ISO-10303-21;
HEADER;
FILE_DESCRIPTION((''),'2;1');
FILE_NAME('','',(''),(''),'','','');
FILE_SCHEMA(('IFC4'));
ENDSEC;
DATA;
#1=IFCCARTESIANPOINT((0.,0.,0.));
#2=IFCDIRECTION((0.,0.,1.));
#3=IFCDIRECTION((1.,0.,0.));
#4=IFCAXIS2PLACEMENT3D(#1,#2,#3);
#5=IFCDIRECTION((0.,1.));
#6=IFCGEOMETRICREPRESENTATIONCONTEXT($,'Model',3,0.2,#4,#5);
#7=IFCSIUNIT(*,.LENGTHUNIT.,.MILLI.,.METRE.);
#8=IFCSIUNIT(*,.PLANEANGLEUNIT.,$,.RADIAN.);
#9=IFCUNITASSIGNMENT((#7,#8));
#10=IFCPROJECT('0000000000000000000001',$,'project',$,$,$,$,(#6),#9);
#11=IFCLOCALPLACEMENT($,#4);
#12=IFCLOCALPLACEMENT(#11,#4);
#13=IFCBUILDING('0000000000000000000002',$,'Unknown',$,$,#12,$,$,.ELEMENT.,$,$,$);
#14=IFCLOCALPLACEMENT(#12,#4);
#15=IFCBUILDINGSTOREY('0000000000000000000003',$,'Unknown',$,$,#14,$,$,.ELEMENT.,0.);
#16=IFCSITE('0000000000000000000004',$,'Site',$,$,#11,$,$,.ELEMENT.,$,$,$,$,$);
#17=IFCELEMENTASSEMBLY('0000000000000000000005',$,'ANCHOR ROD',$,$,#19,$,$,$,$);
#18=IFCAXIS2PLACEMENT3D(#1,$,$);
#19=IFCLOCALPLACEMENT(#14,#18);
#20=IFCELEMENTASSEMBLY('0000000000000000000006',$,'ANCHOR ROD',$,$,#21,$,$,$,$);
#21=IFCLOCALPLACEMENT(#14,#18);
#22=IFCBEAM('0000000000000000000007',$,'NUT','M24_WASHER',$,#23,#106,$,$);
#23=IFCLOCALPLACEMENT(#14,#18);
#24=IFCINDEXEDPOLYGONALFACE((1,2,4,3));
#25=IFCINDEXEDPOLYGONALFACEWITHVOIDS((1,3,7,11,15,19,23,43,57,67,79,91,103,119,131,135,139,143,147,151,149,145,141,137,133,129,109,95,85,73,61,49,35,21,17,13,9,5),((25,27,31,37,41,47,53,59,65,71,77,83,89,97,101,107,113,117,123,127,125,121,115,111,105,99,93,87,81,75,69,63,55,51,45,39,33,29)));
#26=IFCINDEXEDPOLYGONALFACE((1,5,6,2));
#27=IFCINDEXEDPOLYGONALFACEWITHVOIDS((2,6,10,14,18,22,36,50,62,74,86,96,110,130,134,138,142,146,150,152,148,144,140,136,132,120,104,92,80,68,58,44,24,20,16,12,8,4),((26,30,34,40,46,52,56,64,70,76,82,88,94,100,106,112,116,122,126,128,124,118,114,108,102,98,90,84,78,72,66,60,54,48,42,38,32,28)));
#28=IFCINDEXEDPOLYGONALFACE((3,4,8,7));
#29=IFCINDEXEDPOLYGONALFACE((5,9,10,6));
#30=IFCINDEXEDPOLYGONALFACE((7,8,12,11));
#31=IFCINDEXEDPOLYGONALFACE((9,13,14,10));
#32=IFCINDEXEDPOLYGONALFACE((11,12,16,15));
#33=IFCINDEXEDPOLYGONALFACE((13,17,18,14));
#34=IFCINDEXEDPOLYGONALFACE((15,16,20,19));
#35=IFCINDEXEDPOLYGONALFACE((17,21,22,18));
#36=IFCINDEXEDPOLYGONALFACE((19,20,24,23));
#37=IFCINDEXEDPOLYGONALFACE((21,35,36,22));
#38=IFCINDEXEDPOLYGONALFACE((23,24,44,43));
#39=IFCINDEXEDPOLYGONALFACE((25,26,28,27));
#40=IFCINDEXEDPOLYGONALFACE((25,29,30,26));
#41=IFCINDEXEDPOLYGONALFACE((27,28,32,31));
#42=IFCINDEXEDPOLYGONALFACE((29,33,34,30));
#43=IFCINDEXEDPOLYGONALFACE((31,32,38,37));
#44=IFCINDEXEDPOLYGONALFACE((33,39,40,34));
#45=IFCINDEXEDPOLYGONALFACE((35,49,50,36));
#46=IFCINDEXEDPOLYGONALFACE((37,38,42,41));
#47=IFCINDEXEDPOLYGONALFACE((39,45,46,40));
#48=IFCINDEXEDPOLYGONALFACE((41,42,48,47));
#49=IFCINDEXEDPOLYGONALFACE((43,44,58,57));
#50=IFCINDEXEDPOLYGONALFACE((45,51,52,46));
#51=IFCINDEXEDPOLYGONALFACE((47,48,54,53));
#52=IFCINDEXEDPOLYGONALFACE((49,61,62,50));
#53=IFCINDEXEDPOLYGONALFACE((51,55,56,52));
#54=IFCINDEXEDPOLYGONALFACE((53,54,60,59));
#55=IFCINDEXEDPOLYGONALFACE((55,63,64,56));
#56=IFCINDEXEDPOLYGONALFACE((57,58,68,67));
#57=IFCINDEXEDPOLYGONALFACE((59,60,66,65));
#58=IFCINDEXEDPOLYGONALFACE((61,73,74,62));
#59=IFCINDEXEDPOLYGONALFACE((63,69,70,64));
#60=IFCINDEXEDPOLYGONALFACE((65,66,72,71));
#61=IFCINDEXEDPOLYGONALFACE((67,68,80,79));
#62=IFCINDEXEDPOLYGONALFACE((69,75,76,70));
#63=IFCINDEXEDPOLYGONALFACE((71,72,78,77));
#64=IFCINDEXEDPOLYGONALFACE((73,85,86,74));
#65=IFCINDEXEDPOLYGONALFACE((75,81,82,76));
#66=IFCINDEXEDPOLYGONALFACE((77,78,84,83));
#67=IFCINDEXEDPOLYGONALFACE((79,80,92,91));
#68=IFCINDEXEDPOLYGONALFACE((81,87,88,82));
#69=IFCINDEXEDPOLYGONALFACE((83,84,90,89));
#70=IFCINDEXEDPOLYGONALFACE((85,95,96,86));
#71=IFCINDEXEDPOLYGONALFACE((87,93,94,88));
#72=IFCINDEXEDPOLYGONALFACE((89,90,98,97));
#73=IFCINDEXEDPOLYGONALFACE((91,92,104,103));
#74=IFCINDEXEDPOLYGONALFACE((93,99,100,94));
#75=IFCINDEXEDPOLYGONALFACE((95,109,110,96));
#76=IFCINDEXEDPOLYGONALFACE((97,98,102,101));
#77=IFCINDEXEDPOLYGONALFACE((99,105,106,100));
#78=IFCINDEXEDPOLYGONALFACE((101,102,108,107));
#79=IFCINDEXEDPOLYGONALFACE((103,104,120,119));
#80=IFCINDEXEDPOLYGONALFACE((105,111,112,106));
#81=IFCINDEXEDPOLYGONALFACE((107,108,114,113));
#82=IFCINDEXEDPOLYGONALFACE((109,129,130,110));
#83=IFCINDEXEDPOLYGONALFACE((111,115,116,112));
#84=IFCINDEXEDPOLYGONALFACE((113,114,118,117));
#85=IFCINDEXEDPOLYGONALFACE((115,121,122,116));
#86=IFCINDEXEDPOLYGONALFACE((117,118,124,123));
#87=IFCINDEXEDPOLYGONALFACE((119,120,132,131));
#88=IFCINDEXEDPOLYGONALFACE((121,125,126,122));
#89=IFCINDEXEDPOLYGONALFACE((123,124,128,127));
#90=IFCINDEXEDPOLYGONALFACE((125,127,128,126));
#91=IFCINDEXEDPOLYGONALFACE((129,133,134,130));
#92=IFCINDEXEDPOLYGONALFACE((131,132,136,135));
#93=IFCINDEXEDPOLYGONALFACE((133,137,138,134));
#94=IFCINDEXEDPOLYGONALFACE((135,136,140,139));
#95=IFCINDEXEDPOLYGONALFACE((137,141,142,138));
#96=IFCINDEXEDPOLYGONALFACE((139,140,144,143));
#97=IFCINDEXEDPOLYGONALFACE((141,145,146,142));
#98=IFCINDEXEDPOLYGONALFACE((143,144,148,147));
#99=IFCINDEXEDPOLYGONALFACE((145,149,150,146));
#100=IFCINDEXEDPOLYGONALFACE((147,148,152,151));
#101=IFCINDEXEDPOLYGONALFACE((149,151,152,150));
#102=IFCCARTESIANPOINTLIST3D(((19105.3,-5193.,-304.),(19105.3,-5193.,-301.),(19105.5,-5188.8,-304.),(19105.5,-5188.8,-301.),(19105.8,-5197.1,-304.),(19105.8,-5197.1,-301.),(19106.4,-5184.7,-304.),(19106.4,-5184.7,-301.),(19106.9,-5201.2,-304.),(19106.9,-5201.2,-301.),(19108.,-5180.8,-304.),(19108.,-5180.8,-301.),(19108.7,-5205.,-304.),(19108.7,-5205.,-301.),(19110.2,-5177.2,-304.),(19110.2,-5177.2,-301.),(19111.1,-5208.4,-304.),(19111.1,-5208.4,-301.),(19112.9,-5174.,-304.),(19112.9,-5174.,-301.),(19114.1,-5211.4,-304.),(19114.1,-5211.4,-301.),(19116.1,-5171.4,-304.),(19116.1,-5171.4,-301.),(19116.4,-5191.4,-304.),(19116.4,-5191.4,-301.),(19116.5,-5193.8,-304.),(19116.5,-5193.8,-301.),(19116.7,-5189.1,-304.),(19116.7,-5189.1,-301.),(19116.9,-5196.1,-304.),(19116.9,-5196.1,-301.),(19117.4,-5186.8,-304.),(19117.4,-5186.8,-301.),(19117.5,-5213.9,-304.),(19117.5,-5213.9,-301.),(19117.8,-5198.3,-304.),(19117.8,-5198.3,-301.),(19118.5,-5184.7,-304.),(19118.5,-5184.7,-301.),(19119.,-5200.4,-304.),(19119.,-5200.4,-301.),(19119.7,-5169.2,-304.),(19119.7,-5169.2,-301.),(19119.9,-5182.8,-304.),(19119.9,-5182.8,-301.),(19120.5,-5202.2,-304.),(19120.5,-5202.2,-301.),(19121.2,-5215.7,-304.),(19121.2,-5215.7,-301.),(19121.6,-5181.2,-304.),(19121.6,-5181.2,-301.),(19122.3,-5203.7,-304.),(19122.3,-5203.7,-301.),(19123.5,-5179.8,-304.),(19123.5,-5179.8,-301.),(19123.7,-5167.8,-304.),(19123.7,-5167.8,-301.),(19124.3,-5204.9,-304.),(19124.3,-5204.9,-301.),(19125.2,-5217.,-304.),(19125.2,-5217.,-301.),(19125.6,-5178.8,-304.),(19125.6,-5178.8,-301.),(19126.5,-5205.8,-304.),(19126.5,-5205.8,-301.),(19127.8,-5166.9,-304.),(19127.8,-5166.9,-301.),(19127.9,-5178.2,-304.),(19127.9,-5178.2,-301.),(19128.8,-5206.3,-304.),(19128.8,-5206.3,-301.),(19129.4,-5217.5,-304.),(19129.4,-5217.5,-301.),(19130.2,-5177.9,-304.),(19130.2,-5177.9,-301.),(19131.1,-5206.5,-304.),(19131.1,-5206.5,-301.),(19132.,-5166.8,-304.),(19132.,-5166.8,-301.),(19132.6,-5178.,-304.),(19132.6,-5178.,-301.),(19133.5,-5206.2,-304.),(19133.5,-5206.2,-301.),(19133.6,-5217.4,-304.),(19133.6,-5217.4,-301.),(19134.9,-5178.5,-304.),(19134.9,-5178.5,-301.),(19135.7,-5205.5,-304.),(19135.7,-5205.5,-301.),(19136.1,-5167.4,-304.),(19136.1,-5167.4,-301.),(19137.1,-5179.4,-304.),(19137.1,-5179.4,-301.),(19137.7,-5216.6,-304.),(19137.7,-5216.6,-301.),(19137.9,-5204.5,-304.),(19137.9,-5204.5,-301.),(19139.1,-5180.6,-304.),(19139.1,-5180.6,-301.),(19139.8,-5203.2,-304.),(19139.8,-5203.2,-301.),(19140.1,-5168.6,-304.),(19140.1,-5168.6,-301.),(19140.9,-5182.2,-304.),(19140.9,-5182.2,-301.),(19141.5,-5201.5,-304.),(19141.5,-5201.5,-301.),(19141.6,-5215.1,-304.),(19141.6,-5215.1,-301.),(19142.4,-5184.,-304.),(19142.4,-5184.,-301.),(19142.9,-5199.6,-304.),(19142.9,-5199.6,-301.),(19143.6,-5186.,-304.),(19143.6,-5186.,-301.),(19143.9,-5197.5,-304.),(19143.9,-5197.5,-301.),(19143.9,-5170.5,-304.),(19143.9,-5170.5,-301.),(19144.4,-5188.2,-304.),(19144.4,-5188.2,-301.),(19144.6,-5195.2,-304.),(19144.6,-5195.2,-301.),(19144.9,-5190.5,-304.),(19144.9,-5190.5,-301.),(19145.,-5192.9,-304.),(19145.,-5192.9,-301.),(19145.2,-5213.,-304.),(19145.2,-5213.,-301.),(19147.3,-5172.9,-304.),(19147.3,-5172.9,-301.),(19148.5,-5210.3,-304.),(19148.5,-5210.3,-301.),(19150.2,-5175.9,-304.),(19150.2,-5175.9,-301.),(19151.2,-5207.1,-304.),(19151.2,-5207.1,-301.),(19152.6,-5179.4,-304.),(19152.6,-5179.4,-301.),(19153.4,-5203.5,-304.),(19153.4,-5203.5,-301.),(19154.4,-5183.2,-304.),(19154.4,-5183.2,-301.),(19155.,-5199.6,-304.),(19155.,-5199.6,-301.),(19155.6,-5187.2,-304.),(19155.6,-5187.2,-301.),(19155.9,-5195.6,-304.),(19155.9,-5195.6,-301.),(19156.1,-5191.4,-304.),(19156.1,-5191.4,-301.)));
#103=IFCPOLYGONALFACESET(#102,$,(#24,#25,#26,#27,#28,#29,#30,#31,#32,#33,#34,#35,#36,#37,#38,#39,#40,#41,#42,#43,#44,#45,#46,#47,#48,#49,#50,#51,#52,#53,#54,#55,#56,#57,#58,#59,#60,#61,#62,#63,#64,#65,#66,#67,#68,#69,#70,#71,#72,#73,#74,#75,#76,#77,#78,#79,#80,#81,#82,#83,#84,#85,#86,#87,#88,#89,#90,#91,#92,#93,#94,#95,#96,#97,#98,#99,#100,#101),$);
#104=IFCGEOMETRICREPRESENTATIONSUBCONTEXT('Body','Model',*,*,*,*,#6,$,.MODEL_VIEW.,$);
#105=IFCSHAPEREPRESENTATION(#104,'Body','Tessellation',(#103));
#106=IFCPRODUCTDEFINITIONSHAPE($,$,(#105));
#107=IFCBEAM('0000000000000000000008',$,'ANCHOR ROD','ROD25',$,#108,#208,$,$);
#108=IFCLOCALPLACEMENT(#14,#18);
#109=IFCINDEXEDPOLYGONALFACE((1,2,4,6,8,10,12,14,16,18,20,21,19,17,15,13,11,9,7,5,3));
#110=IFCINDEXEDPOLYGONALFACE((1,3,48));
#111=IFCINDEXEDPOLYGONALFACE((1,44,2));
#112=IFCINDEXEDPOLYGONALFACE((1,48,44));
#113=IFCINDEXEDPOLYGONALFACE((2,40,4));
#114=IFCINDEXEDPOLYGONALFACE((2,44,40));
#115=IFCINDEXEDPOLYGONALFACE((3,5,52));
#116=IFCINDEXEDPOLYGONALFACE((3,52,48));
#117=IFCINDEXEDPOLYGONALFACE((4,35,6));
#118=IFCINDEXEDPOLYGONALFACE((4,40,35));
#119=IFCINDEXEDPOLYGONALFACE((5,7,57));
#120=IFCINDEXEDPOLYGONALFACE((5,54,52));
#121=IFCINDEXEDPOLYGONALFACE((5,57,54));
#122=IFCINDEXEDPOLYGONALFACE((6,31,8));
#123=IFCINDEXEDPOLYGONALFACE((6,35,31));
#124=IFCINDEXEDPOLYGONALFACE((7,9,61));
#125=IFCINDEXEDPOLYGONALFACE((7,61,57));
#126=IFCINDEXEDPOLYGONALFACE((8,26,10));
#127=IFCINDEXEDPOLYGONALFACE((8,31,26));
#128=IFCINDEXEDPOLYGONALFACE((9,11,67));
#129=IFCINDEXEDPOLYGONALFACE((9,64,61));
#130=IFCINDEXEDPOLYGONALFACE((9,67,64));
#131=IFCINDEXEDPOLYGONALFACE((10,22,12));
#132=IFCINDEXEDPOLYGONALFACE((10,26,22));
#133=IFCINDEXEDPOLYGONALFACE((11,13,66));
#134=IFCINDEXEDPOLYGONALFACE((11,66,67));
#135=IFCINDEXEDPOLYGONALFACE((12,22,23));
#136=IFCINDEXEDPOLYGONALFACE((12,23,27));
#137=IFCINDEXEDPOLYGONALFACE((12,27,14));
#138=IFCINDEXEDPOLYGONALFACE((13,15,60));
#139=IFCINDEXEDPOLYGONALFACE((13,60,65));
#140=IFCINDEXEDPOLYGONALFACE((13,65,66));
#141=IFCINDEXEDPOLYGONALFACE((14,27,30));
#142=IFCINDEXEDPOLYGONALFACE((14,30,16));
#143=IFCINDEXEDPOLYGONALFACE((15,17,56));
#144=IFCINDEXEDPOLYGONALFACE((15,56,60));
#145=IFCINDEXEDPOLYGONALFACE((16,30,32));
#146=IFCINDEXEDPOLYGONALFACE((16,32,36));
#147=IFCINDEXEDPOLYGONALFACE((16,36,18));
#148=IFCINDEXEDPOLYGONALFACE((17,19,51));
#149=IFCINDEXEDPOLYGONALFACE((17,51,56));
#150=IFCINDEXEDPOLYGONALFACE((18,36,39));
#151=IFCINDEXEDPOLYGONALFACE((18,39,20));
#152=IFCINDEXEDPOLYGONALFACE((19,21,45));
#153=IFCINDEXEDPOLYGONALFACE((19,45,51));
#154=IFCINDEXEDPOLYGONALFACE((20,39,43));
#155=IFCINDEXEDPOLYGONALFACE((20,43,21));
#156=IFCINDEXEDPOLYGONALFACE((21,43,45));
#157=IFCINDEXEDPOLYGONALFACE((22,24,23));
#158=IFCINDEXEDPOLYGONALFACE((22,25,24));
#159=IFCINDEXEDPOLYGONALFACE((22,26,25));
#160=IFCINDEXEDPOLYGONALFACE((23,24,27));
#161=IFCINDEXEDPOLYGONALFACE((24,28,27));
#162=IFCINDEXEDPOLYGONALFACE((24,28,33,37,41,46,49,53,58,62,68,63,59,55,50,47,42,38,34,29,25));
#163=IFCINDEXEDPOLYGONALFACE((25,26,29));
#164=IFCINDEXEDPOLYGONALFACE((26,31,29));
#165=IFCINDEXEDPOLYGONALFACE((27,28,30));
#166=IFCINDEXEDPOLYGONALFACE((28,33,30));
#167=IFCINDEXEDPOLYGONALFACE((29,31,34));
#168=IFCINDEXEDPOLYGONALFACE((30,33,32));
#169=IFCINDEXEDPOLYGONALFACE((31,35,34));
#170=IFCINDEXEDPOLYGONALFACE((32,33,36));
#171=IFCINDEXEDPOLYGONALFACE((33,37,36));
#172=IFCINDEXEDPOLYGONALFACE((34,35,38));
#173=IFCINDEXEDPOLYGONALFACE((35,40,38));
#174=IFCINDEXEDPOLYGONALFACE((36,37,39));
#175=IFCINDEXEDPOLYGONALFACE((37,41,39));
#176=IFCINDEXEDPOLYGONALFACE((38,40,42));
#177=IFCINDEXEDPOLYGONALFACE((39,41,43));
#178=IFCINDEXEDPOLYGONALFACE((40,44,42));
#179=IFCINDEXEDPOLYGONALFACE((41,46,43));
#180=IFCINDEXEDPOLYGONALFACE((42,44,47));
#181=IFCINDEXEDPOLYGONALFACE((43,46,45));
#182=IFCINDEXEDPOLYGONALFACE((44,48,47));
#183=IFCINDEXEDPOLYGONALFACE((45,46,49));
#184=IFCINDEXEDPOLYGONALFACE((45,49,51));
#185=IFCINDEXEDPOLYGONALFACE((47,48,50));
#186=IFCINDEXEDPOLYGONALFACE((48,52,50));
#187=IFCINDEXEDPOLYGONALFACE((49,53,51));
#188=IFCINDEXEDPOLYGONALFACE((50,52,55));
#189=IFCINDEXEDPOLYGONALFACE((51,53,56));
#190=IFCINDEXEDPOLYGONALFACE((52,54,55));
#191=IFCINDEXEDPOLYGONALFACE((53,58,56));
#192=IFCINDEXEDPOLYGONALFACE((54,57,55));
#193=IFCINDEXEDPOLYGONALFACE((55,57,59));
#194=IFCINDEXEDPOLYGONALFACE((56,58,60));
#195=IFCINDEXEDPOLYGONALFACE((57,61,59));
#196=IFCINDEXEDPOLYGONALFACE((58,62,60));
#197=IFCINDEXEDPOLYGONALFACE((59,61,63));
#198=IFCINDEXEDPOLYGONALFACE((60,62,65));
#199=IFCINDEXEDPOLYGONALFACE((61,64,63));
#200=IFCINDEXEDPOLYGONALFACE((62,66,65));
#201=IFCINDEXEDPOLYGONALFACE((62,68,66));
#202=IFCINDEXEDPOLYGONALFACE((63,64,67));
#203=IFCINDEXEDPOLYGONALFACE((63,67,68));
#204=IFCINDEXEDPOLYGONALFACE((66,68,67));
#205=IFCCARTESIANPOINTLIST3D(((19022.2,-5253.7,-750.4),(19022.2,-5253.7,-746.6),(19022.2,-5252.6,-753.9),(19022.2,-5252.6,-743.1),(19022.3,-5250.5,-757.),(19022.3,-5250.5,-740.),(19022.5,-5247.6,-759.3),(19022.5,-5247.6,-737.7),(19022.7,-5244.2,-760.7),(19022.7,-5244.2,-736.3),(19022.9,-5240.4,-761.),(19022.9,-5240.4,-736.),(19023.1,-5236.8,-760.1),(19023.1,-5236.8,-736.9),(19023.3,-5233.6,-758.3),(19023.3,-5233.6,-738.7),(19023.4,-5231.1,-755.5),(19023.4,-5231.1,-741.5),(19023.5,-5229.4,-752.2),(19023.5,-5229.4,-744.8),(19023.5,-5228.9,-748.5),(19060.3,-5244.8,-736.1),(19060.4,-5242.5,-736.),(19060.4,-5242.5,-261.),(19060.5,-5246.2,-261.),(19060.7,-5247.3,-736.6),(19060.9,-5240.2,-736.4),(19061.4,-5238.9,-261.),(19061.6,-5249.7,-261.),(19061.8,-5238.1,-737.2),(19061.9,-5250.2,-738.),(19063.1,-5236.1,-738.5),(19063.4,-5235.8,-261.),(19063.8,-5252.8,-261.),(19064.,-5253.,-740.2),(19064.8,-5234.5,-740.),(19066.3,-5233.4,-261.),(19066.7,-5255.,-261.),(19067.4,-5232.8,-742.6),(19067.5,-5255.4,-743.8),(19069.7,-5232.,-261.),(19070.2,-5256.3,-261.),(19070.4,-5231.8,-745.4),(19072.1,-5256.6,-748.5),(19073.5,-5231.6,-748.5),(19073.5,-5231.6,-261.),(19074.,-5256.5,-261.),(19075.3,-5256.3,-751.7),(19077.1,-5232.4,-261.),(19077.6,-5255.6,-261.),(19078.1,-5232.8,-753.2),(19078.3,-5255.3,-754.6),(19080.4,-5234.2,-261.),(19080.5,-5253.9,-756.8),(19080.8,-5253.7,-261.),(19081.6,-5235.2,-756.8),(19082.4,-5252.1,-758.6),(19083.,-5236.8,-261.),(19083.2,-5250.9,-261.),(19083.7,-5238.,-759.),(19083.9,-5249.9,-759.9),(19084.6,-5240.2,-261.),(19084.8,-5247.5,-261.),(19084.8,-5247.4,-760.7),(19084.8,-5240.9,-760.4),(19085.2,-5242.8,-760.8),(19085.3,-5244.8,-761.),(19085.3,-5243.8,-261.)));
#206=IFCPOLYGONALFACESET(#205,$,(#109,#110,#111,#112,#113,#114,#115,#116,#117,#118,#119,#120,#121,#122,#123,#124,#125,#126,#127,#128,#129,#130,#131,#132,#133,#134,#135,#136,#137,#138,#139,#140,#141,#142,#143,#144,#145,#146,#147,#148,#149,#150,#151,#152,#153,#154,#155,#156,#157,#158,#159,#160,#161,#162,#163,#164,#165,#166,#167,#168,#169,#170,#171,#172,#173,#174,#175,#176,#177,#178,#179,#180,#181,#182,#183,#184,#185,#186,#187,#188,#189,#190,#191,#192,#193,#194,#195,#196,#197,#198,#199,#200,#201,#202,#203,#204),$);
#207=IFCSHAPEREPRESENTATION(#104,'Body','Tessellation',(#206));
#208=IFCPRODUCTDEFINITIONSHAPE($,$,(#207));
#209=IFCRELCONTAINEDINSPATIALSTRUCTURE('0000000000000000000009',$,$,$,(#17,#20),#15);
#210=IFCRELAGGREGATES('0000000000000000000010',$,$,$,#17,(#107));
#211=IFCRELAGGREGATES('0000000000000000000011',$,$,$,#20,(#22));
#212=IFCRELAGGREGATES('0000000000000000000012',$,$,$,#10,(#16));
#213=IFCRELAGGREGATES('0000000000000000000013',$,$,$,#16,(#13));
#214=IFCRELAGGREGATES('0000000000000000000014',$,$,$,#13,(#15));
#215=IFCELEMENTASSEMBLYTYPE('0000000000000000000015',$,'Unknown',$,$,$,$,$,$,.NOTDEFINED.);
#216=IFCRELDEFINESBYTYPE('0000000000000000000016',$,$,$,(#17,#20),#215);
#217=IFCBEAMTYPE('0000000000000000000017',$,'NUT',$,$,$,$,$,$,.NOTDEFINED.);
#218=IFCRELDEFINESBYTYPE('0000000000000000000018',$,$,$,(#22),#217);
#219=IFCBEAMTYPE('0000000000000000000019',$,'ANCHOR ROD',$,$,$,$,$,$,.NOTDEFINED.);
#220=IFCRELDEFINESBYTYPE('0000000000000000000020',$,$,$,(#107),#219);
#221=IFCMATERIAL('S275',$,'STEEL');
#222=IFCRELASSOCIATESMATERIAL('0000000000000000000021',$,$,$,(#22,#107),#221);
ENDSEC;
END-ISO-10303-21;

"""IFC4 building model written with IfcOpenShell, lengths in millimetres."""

from ifc_helpers import new_model, entity, si_unit, direction, frame, origin_with_axes, place, context, subcontext, project, spatial, polyline, outline, extrude, material, material_profile, profile_set, profile_usage, type_object, element, aggregate, save


model = new_model("IFC4")

# Units and contexts
model_context = context("Model", 3, precision=0.2, world=origin_with_axes(), true_north=direction((0.0, 1.0)))
body_context = subcontext(model_context, "Body", "Model", "MODEL_VIEW")
ifc_project = project(units=[si_unit("LENGTHUNIT", "METRE", prefix="MILLI"), si_unit("PLANEANGLEUNIT", "RADIAN")], contexts=[model_context])

# Site, building, storey
site_placement = place(None, origin_with_axes())
site = spatial("IfcSite", under=ifc_project, at=site_placement, Name="Site", CompositionType="ELEMENT")
building_placement = place(site_placement, origin_with_axes())
building = spatial("IfcBuilding", under=site, at=building_placement, Name="Unknown", CompositionType="ELEMENT")
storey_placement = place(building_placement, origin_with_axes())
storey = spatial("IfcBuildingStorey", under=building, at=storey_placement, Name="Unknown", CompositionType="ELEMENT", Elevation=0.0)

# Element assemblies, beam
element_assembly_type = type_object("IfcElementAssemblyType", Name="Unknown", PredefinedType="NOTDEFINED")
assembly_1_placement = place(storey_placement, frame((19072.8, -5244.1, -261.0), z_axis=(0.054389, 0.99852, 0.0), x_axis=(0.0, 0.0, -1.0)))
assembly_1 = element("IfcElementAssembly", 1, at=assembly_1_placement, inside=storey, type_object=element_assembly_type, Name="ANCHOR ROD")
ifc_material_1 = material(Name="S275", Category="STEEL")
ifc_material_profile_1 = material_profile(ifc_material_1, outline(polyline([(25.4, 0.0), (25.1, 4.2), (24.0, 8.2), (22.3, 12.1), (20.0, 15.6), (17.2, 18.7), (13.9, 21.3), (10.2, 23.3), (6.2, 24.6), (2.1, 25.3), (-2.1, 25.3), (-6.2, 24.6), (-10.2, 23.3), (-13.9, 21.3), (-17.2, 18.7), (-20.0, 15.6), (-22.3, 12.1), (-24.0, 8.2), (-25.1, 4.2), (-25.4, 0.0), (-25.1, -4.2), (-24.0, -8.2), (-22.3, -12.1), (-20.0, -15.6), (-17.2, -18.7), (-13.9, -21.3), (-10.2, -23.3), (-6.2, -24.6), (-2.1, -25.3), (2.1, -25.3), (6.2, -24.6), (10.2, -23.3), (13.9, -21.3), (17.2, -18.7), (20.0, -15.6), (22.3, -12.1), (24.0, -8.2), (25.1, -4.2), (25.4, 0.0)]), holes=[polyline([(0.0, 14.3), (2.4, 14.1), (4.6, 13.5), (6.8, 12.6), (8.8, 11.3), (10.5, 9.7), (12.0, 7.8), (13.1, 5.7), (13.9, 3.5), (14.2, 1.2), (14.2, -1.2), (13.9, -3.5), (13.1, -5.7), (12.0, -7.8), (10.5, -9.7), (8.8, -11.3), (6.8, -12.6), (4.6, -13.5), (2.4, -14.1), (0.0, -14.3), (-2.4, -14.1), (-4.6, -13.5), (-6.8, -12.6), (-8.8, -11.3), (-10.5, -9.7), (-12.0, -7.8), (-13.1, -5.7), (-13.9, -3.5), (-14.2, -1.2), (-14.2, 1.2), (-13.9, 3.5), (-13.1, 5.7), (-12.0, 7.8), (-10.5, 9.7), (-8.8, 11.3), (-6.8, 12.6), (-4.6, 13.5), (-2.4, 14.1), (0.0, 14.3)])]), Name="M24_WASHER")
ifc_profile_set_1 = profile_set([ifc_material_profile_1])
ifc_profile_usage_1 = profile_usage(ifc_profile_set_1, cardinal=5)
beam_type_1 = type_object("IfcBeamType", Name="NUT", PredefinedType="NOTDEFINED")
assembly_2_placement = place(storey_placement, frame((19130.7, -5192.2, -261.0), z_axis=(0.054389, 0.99852, 0.0), x_axis=(0.0, 0.0, -1.0)))
assembly_2 = element("IfcElementAssembly", 2, at=assembly_2_placement, inside=storey, type_object=element_assembly_type, Name="ANCHOR ROD")
beam_1_placement = place(assembly_2_placement, frame((40.0, 0.0, 0.0), z_axis=(0.0, 0.003456, 0.999994), x_axis=(1.0, 0.0, 0.0)))
beam_1 = element("IfcBeam", 3, at=beam_1_placement, type_object=beam_type_1, material=ifc_profile_usage_1, Name="NUT", Description="M24_WASHER", context=body_context, shape_type="SolidModel", body=[
    extrude(outline(polyline([(25.4, 0.0), (25.1, 4.2), (24.0, 8.2), (22.3, 12.1), (20.0, 15.6), (17.2, 18.7), (13.9, 21.3), (10.2, 23.3), (6.2, 24.6), (2.1, 25.3), (-2.1, 25.3), (-6.2, 24.6), (-10.2, 23.3), (-13.9, 21.3), (-17.2, 18.7), (-20.0, 15.6), (-22.3, 12.1), (-24.0, 8.2), (-25.1, 4.2), (-25.4, 0.0), (-25.1, -4.2), (-24.0, -8.2), (-22.3, -12.1), (-20.0, -15.6), (-17.2, -18.7), (-13.9, -21.3), (-10.2, -23.3), (-6.2, -24.6), (-2.1, -25.3), (2.1, -25.3), (6.2, -24.6), (10.2, -23.3), (13.9, -21.3), (17.2, -18.7), (20.0, -15.6), (22.3, -12.1), (24.0, -8.2), (25.1, -4.2), (25.4, 0.0)]), holes=[polyline([(0.0, 14.3), (2.4, 14.1), (4.6, 13.5), (6.8, 12.6), (8.8, 11.3), (10.5, 9.7), (12.0, 7.8), (13.1, 5.7), (13.9, 3.5), (14.2, 1.2), (14.2, -1.2), (13.9, -3.5), (13.1, -5.7), (12.0, -7.8), (10.5, -9.7), (8.8, -11.3), (6.8, -12.6), (4.6, -13.5), (2.4, -14.1), (0.0, -14.3), (-2.4, -14.1), (-4.6, -13.5), (-6.8, -12.6), (-8.8, -11.3), (-10.5, -9.7), (-12.0, -7.8), (-13.1, -5.7), (-13.9, -3.5), (-14.2, -1.2), (-14.2, 1.2), (-13.9, 3.5), (-13.1, 5.7), (-12.0, 7.8), (-10.5, 9.7), (-8.8, 11.3), (-6.8, 12.6), (-4.6, 13.5), (-2.4, 14.1), (0.0, 14.3)])]), frame((0.0, 0.0, 0.0), z_axis=(-1.0, 0.0, 0.0), x_axis=(0.0, 0.0, 1.0)), (0.0, 0.0, -1.0), 3.0),
])

# Beam
beam_type_2 = type_object("IfcBeamType", Name="ANCHOR ROD", PredefinedType="NOTDEFINED")
beam_2_placement = place(assembly_1_placement, origin_with_axes())
beam_2 = element("IfcBeam", 4, at=beam_2_placement, type_object=beam_type_2, material=ifc_material_1, Name="ANCHOR ROD", Description="ROD25", context=body_context, shape_type="SolidModel", body=[
    entity("IfcSweptDiskSolid", entity("IfcIndexedPolyCurve", entity("IfcCartesianPointList3D", [[0.0, 0.0, 0.0], [487.5, 0.0, 0.0], [487.5, 50.0, 0.0]]), [entity("IfcLineIndex", [1, 2, 3])]), 12.5),
])
aggregate(assembly_1, [beam_2])
aggregate(assembly_2, [beam_1])

save(model, "model.ifc")
